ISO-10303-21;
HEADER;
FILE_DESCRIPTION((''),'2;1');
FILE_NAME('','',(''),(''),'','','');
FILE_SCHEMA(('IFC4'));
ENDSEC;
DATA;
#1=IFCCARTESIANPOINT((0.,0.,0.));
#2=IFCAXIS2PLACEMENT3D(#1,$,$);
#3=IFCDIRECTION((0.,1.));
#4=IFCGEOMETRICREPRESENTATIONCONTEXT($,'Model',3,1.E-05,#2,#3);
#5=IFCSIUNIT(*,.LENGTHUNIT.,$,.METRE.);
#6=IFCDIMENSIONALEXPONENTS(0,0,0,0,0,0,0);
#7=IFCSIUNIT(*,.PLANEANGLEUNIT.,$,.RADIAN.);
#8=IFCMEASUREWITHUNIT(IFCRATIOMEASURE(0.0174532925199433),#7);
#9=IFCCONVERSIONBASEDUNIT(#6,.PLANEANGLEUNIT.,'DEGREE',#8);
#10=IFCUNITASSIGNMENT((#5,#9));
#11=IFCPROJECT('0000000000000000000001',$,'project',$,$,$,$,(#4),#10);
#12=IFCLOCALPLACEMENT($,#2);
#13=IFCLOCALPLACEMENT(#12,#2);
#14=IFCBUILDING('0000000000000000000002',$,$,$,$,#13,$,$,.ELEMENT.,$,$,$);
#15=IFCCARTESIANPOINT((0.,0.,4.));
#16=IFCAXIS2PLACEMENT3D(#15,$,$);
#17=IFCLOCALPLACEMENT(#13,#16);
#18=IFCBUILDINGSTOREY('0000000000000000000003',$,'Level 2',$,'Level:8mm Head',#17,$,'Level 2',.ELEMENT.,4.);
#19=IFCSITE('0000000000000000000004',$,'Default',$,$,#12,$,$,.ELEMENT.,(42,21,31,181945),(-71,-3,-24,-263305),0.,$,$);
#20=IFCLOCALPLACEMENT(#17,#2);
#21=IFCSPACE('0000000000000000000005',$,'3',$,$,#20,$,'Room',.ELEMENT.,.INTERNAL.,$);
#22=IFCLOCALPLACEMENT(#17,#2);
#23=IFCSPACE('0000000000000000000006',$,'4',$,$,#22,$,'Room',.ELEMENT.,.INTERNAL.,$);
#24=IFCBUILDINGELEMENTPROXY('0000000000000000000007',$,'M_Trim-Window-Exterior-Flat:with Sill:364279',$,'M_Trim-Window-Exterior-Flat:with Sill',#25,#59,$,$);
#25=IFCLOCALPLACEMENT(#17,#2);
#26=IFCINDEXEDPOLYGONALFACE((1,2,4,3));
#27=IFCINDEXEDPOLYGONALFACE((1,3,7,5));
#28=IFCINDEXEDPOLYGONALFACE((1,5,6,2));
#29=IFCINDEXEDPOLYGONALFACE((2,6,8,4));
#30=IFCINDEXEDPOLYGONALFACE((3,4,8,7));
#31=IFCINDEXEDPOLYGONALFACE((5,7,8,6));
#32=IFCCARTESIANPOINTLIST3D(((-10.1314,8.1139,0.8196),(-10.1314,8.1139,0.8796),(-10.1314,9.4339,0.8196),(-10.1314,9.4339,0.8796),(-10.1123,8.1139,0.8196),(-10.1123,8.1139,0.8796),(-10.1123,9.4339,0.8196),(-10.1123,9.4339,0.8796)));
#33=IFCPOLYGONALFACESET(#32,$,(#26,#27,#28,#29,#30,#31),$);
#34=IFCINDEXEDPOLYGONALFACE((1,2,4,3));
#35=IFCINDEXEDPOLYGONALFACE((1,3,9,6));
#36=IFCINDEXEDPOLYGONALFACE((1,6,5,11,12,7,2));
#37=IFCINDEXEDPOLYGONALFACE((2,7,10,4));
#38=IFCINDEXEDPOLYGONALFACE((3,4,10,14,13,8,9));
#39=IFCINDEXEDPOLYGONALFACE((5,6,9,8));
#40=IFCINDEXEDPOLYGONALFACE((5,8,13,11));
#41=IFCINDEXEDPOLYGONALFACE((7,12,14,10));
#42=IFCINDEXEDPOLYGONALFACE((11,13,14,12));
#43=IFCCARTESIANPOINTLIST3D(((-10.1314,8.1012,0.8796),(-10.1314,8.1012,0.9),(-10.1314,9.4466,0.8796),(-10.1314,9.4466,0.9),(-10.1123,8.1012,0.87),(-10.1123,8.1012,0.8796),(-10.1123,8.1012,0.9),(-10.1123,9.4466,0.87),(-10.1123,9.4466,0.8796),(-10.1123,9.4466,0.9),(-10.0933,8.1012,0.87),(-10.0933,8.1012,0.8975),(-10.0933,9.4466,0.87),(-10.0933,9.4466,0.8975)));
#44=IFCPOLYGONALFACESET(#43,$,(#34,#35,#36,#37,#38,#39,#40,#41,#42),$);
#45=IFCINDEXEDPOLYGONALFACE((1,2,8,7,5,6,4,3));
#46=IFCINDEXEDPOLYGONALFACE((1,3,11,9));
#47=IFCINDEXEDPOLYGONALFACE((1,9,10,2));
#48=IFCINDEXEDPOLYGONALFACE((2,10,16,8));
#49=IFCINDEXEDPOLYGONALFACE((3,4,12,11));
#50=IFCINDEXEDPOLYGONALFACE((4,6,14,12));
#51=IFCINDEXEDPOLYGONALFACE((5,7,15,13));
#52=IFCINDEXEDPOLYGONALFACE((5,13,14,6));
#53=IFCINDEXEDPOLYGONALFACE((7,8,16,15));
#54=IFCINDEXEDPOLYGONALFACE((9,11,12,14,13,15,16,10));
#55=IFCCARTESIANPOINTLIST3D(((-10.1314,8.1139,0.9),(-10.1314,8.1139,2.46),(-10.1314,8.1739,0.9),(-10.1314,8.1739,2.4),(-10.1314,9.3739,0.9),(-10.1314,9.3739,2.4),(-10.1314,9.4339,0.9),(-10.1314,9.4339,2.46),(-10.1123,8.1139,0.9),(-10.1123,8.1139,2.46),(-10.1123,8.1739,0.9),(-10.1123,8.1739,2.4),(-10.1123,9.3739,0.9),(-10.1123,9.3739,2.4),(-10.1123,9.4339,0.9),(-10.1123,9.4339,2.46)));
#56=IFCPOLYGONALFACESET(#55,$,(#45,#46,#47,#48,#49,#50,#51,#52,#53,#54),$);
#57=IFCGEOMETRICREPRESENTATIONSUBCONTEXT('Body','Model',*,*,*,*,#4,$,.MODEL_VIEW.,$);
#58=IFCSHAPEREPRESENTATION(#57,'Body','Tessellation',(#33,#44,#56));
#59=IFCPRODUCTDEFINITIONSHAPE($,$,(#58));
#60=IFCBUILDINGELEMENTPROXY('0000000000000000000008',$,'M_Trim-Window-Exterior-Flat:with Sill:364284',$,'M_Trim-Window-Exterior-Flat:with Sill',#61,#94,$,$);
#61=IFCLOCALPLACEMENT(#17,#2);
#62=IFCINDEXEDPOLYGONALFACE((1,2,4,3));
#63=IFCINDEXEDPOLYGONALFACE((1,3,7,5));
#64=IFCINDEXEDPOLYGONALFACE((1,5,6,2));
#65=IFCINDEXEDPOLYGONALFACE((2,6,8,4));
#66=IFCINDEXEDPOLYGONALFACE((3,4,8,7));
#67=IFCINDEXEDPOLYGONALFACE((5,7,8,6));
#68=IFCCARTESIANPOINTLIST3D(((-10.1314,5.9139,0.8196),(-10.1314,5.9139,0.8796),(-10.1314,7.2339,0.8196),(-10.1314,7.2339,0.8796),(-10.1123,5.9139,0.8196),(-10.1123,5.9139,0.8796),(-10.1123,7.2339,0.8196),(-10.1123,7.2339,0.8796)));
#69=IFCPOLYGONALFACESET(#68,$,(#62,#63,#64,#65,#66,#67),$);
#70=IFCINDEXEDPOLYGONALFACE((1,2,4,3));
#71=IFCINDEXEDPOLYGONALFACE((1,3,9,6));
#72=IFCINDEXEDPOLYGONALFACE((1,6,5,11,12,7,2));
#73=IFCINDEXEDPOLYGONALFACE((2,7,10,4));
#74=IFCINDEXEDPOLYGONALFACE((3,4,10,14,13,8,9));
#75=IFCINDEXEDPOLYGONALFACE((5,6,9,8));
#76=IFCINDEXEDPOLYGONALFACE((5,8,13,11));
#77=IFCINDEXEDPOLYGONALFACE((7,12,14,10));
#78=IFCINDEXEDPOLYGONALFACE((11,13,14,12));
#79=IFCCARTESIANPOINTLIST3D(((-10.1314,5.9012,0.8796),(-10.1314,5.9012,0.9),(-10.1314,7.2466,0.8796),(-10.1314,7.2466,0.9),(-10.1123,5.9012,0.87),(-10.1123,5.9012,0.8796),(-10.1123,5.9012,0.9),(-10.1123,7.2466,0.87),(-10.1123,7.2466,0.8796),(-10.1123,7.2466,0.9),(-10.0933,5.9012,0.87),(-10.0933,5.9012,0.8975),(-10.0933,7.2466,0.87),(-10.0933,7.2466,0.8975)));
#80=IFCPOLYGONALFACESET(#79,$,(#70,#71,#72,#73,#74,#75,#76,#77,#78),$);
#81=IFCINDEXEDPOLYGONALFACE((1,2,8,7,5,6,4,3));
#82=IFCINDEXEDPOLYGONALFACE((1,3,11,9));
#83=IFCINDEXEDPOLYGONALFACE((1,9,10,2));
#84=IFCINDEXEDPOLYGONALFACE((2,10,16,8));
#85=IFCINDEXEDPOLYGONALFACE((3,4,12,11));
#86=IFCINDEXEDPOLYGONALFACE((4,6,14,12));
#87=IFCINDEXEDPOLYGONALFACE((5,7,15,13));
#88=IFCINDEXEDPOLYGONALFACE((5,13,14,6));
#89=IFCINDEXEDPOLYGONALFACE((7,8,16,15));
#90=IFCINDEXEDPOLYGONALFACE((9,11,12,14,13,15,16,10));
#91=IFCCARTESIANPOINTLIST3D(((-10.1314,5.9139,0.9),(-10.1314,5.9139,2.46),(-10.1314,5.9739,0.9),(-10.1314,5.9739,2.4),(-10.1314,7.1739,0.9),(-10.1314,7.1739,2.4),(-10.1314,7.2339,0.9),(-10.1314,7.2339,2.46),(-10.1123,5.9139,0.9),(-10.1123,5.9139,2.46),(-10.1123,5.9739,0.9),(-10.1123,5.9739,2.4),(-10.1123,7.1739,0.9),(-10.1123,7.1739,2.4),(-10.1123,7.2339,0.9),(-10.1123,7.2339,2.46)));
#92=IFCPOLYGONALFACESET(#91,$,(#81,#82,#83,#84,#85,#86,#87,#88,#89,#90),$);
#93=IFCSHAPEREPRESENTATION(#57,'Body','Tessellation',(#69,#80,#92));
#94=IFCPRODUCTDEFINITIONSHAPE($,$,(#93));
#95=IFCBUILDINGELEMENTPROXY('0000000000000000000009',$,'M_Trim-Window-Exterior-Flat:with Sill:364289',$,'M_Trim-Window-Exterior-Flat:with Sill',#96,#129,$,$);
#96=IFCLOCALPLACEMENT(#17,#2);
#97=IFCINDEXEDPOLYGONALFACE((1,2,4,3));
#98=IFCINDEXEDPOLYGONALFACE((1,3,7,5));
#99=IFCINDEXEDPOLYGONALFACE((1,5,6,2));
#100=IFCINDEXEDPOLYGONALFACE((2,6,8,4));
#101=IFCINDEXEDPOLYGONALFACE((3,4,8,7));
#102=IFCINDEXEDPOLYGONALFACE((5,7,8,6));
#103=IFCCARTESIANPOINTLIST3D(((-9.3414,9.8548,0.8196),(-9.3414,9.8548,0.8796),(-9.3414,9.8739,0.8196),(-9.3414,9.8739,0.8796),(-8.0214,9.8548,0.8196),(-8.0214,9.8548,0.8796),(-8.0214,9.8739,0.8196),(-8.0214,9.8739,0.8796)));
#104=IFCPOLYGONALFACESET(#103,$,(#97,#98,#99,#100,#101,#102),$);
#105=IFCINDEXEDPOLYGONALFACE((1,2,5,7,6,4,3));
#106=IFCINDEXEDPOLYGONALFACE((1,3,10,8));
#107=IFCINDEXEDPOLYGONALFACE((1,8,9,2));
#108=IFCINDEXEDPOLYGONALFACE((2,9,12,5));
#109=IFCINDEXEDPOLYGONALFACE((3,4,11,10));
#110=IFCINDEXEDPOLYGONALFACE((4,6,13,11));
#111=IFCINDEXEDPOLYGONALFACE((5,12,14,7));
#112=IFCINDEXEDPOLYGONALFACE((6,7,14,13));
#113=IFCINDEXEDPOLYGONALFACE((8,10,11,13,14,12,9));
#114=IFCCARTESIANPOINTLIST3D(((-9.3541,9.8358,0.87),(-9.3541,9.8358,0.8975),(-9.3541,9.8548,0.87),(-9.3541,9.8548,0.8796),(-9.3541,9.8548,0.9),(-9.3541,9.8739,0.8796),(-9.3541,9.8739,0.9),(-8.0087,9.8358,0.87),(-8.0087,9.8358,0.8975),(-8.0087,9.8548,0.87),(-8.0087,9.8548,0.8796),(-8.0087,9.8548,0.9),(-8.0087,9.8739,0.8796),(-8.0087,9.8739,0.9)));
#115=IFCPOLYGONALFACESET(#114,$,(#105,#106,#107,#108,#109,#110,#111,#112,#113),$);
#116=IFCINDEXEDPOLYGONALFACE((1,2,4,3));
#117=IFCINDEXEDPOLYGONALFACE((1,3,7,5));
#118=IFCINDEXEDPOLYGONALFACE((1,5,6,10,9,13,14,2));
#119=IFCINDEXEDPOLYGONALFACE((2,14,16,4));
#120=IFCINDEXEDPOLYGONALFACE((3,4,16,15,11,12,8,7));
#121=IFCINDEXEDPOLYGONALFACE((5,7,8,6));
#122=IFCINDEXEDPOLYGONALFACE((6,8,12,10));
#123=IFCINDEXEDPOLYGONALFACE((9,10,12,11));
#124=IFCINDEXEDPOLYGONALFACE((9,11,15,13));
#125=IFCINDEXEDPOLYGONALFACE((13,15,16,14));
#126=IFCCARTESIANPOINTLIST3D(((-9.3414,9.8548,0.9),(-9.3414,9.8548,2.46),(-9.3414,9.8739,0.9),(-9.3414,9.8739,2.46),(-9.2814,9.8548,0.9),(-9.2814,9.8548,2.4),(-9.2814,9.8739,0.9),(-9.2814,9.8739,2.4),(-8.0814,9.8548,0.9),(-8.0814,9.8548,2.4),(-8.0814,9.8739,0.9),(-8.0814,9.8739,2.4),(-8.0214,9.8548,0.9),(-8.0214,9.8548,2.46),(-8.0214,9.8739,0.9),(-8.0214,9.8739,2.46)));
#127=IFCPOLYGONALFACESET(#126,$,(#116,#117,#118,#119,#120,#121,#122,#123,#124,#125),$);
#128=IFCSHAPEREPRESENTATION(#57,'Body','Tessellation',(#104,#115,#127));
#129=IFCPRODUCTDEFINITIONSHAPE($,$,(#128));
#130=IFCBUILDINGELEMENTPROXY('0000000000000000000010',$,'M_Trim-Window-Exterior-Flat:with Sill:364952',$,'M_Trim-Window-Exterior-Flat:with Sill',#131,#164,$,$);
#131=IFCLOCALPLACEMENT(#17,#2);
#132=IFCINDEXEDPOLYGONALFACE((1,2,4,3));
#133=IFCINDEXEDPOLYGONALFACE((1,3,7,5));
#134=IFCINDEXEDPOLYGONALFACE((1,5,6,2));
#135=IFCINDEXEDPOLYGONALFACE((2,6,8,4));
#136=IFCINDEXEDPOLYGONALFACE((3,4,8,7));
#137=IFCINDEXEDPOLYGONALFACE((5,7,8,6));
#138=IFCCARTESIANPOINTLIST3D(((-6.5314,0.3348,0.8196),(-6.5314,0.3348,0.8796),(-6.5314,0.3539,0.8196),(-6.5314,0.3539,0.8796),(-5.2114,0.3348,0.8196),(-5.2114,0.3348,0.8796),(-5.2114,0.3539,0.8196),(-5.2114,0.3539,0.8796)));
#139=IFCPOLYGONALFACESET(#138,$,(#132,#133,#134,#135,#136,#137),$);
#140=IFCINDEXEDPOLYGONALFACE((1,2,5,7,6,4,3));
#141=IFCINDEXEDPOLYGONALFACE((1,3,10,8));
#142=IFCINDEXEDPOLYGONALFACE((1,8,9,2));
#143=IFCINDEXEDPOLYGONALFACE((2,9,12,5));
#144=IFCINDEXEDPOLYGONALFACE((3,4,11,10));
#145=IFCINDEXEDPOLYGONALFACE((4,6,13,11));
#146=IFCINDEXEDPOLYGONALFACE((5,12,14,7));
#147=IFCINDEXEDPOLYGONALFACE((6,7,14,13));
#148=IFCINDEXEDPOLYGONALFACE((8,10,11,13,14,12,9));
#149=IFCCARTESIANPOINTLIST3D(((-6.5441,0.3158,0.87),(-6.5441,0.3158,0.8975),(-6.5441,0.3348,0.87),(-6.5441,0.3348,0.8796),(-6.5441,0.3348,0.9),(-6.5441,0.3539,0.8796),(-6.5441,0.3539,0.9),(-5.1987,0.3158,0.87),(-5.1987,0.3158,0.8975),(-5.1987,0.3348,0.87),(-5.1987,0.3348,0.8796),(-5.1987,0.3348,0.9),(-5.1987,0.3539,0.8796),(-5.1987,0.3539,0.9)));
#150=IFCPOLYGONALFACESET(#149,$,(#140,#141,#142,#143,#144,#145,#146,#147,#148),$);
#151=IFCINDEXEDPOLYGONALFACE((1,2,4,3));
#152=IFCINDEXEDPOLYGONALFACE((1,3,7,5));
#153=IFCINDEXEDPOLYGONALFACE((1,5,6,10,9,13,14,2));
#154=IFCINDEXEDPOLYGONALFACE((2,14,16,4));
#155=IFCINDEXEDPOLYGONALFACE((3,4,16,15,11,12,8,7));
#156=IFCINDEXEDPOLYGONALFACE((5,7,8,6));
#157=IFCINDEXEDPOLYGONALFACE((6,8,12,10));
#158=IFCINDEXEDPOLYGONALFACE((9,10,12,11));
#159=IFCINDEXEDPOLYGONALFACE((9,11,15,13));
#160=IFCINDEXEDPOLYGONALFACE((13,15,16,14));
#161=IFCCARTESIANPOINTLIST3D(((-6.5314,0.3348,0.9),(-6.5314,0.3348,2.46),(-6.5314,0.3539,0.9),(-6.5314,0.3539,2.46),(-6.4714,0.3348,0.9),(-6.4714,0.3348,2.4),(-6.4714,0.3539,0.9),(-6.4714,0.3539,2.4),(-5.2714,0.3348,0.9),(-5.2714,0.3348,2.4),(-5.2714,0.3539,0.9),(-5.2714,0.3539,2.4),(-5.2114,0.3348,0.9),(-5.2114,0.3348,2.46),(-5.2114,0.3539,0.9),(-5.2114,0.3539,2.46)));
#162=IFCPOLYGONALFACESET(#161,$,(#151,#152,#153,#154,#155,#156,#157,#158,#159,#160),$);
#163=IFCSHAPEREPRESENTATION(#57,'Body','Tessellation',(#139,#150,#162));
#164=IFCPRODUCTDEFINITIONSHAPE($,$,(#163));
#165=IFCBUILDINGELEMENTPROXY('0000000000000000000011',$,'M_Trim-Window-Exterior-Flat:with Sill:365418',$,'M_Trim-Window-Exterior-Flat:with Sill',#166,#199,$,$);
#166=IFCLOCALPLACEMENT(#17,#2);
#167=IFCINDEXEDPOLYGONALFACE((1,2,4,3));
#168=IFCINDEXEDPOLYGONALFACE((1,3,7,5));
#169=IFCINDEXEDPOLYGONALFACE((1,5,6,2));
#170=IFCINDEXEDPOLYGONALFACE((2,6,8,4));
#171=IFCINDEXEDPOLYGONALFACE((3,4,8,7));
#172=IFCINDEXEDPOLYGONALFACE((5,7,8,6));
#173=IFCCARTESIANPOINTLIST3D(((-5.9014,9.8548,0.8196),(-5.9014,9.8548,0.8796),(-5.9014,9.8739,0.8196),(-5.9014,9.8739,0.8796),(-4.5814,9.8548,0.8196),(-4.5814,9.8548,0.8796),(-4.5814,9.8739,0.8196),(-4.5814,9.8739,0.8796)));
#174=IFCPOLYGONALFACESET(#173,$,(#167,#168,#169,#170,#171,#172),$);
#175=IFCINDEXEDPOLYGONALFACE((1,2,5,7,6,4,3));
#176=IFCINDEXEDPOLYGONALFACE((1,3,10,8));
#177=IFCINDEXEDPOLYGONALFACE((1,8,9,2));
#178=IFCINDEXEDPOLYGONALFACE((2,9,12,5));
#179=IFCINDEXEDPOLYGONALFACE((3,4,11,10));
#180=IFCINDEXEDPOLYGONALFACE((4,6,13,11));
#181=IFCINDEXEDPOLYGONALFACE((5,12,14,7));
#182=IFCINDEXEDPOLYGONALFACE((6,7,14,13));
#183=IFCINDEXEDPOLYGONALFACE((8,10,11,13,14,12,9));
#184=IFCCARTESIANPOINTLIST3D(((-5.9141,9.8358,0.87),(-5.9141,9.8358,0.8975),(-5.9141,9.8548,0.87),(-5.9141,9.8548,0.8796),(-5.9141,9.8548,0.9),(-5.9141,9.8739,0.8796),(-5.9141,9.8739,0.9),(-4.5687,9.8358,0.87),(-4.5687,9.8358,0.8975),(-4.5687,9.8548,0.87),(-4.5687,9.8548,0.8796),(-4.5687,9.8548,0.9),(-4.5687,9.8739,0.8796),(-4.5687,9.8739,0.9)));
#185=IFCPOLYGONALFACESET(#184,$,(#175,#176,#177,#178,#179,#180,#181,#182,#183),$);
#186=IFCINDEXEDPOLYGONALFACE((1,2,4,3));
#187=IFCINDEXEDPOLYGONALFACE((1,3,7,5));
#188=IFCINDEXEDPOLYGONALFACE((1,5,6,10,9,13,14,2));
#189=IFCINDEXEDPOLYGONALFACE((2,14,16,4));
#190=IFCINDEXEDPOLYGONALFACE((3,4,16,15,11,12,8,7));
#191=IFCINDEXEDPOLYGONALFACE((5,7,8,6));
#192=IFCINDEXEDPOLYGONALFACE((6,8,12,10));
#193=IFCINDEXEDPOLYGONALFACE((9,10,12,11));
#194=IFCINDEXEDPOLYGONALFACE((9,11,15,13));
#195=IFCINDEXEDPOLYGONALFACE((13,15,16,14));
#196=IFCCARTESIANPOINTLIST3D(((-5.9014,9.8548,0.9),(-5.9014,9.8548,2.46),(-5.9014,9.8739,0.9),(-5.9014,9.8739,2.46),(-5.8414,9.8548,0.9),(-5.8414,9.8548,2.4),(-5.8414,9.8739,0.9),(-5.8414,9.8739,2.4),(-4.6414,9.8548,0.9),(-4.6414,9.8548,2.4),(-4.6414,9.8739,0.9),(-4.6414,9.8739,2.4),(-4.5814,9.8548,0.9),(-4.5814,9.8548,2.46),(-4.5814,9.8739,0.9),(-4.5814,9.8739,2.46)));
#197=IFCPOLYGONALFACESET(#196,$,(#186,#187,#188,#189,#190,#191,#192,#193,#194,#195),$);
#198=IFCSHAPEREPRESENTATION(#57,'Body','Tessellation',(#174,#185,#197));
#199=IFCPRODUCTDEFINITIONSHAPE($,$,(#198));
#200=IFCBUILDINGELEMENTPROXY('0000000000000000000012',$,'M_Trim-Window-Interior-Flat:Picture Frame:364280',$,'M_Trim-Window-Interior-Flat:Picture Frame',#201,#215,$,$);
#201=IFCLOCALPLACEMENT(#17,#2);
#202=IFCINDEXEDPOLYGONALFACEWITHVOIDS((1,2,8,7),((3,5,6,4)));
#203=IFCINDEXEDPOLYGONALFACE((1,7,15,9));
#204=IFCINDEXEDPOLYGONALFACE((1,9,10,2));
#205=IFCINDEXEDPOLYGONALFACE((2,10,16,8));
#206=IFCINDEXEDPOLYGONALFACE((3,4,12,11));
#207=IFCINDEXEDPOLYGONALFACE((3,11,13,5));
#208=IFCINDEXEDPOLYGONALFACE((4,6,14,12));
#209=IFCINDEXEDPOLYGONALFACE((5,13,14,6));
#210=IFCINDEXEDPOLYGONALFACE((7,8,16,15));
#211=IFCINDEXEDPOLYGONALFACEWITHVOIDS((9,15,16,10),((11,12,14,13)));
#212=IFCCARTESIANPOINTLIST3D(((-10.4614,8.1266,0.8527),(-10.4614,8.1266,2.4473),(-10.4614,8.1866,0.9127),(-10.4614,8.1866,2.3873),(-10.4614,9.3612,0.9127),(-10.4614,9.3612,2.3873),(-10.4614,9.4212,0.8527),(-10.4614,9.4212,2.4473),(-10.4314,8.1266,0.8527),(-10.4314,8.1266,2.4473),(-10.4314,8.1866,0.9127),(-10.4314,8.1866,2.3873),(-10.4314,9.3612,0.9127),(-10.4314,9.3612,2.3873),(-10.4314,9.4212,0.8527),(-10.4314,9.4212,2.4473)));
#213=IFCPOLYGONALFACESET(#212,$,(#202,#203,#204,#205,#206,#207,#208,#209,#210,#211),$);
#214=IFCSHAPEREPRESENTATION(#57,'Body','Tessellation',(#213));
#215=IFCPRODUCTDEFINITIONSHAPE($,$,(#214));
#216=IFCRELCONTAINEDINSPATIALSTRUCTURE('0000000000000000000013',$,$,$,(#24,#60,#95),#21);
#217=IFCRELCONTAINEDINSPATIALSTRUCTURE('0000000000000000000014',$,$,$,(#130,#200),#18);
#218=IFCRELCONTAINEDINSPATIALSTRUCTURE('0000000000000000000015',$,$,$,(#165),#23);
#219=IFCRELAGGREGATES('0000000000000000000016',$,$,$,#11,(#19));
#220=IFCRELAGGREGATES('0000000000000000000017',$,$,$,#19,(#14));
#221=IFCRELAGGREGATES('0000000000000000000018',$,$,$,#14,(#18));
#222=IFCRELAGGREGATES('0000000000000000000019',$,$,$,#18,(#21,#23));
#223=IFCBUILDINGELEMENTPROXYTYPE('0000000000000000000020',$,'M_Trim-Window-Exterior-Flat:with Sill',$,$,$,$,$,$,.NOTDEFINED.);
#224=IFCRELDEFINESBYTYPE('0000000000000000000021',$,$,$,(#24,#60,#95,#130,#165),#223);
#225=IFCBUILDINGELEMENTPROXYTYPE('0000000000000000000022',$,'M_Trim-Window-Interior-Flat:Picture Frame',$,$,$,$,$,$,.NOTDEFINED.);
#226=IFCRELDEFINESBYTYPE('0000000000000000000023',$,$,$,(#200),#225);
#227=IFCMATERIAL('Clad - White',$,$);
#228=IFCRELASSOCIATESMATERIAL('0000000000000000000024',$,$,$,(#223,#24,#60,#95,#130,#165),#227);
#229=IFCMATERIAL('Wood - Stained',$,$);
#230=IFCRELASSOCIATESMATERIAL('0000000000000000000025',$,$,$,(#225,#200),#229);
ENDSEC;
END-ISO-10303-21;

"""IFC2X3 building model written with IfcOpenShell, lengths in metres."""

from ifc_helpers import new_model, entity, si_unit, converted_unit, direction, frame, frame_2d, origin, place, context, subcontext, project, spatial, polyline, rectangle, outline, extrude, source, transform, mapped, material, type_object, type_shapes, element, save


model = new_model("IFC2X3")

# Units and contexts
model_context = context("Model", 3, precision=1e-05, world=origin(), true_north=direction((0.0, 1.0)))
body_context = subcontext(model_context, "Body", "Model", "MODEL_VIEW")
ifc_project = project(units=[si_unit("LENGTHUNIT", "METRE"), converted_unit("PLANEANGLEUNIT", "DEGREE", entity("IfcRatioMeasure", 0.0174532925199433), si_unit("PLANEANGLEUNIT", "RADIAN"), dimensions=[0, 0, 0, 0, 0, 0, 0])], contexts=[model_context])

# Site, building, storey
site_placement = place(None, origin())
site = spatial("IfcSite", under=ifc_project, at=site_placement, Name="Default", CompositionType="ELEMENT", RefLatitude=(42, 21, 31, 181945), RefLongitude=(-71, -3, -24, -263305), RefElevation=0.0)
building_placement = place(site_placement, origin())
building = spatial("IfcBuilding", under=site, at=building_placement, CompositionType="ELEMENT")
storey_placement = place(building_placement, frame((0.0, 0.0, 4.0)))
storey = spatial("IfcBuildingStorey", under=building, at=storey_placement, Name="Level 2", ObjectType="Level:8mm Head", LongName="Level 2", CompositionType="ELEMENT", Elevation=4.0)

# Shared definitions
ifc_material_1 = material(Name="Clad - White")
ifc_material_2 = material(Name="Wood - Stained")

# Shared definitions
space_1_placement = place(storey_placement, origin())
space_1 = spatial("IfcSpace", under=storey, at=space_1_placement, Name="3", LongName="Room", CompositionType="ELEMENT", InteriorOrExteriorSpace="INTERNAL")

# Building element proxies
building_element_proxy_type_1 = type_object("IfcBuildingElementProxyType", Name="M_Trim-Window-Exterior-Flat:with Sill", PredefinedType="NOTDEFINED", material=ifc_material_1)
shared_shape_1 = source(origin(), body_context, "Body", "SweptSolid", [
    extrude(rectangle(XDim=1.32, YDim=0.06, at=frame_2d((0.0, 0.0), x_axis=(1.0, 0.0))), frame((0.0, -1.5504, 0.0), z_axis=(0.0, 0.0, 1.0), x_axis=(-1.0, 0.0, 0.0)), (0.0, 0.0, 1.0), 0.0191),
    extrude(outline(polyline([(-0.019, -0.0152), (0.0, -0.0152), (0.0, -0.0057), (0.019, -0.0057), (0.019, 0.0148), (0.0, 0.0148), (-0.019, 0.0123), (-0.019, -0.0152)])), frame((-0.6727, -1.5148, 0.019), z_axis=(1.0, 0.0, 0.0), x_axis=(0.0, 0.0, -1.0)), (0.0, 0.0, 1.0), 1.3454),
    extrude(outline(polyline([(-0.795, -0.66), (0.765, -0.66), (0.765, -0.6), (-0.735, -0.6), (-0.735, 0.6), (0.765, 0.6), (0.765, 0.66), (-0.795, 0.66), (-0.795, -0.66)])), frame((0.0, -0.735, 0.0), z_axis=(0.0, 0.0, 1.0), x_axis=(0.0, -1.0, 0.0)), (0.0, 0.0, 1.0), 0.0191),
])
type_shapes(building_element_proxy_type_1, [shared_shape_1])
for number, where, z_axis, x_axis, name in (
    (1, (-10.1314, 8.7739, 2.4), (1.0, 0.0, 0.0), (0.0, 1.0, 0.0), "M_Trim-Window-Exterior-Flat:with Sill:364279"),
    (2, (-10.1314, 6.5739, 2.4), (1.0, 0.0, 0.0), (0.0, 1.0, 0.0), "M_Trim-Window-Exterior-Flat:with Sill:364284"),
    (3, (-8.6814, 9.8739, 2.4), (0.0, -1.0, 0.0), (1.0, 0.0, 0.0), "M_Trim-Window-Exterior-Flat:with Sill:364289"),
):
    element("IfcBuildingElementProxy", number, at=place(space_1_placement, frame(where, z_axis=z_axis, x_axis=x_axis)), inside=space_1, type_object=building_element_proxy_type_1, material=ifc_material_1, Name=name, ObjectType="M_Trim-Window-Exterior-Flat:with Sill", context=body_context, shape_type="MappedRepresentation", body=[
        mapped(shared_shape_1, transform((0.0, 0.0, 0.0), scale=1.0)),
    ])
proxy_1_placement = place(storey_placement, frame((-5.8714, 0.3539, 2.4), z_axis=(0.0, -1.0, 0.0), x_axis=(1.0, 0.0, 0.0)))
element("IfcBuildingElementProxy", 4, at=proxy_1_placement, inside=storey, type_object=building_element_proxy_type_1, material=ifc_material_1, Name="M_Trim-Window-Exterior-Flat:with Sill:364952", ObjectType="M_Trim-Window-Exterior-Flat:with Sill", context=body_context, shape_type="MappedRepresentation", body=[
    mapped(shared_shape_1, transform((0.0, 0.0, 0.0), scale=1.0)),
])

# Shared definitions
space_2_placement = place(storey_placement, origin())
space_2 = spatial("IfcSpace", under=storey, at=space_2_placement, Name="4", LongName="Room", CompositionType="ELEMENT", InteriorOrExteriorSpace="INTERNAL")

# Building element proxies
proxy_2_placement = place(space_2_placement, frame((-5.2414, 9.8739, 2.4), z_axis=(0.0, -1.0, 0.0), x_axis=(1.0, 0.0, 0.0)))
element("IfcBuildingElementProxy", 5, at=proxy_2_placement, inside=space_2, type_object=building_element_proxy_type_1, material=ifc_material_1, Name="M_Trim-Window-Exterior-Flat:with Sill:365418", ObjectType="M_Trim-Window-Exterior-Flat:with Sill", context=body_context, shape_type="MappedRepresentation", body=[
    mapped(shared_shape_1, transform((0.0, 0.0, 0.0), scale=1.0)),
])
building_element_proxy_type_2 = type_object("IfcBuildingElementProxyType", Name="M_Trim-Window-Interior-Flat:Picture Frame", PredefinedType="NOTDEFINED", material=ifc_material_2)
shared_shape_2 = source(origin(), body_context, "Body", "SweptSolid", [
    extrude(outline(polyline([(-0.6473, -0.7973), (0.6473, -0.7973), (0.6473, 0.7973), (-0.6473, 0.7973), (-0.6473, -0.7973)]), holes=[polyline([(-0.5873, -0.7373), (-0.5873, 0.7373), (0.5873, 0.7373), (0.5873, -0.7373), (-0.5873, -0.7373)])]), frame((0.0, -0.75, 0.0), z_axis=(0.0, 0.0, 1.0), x_axis=(-1.0, 0.0, 0.0)), (0.0, 0.0, 1.0), 0.03),
])
type_shapes(building_element_proxy_type_2, [shared_shape_2])
for number, where, z_axis, x_axis, name in (
    (6, (-10.4314, 8.7739, 2.4), (-1.0, 0.0, 0.0), (0.0, -1.0, 0.0), "M_Trim-Window-Interior-Flat:Picture Frame:364280"),
):
    element("IfcBuildingElementProxy", number, at=place(storey_placement, frame(where, z_axis=z_axis, x_axis=x_axis)), inside=storey, type_object=building_element_proxy_type_2, material=ifc_material_2, Name=name, ObjectType="M_Trim-Window-Interior-Flat:Picture Frame", context=body_context, shape_type="MappedRepresentation", body=[
        mapped(shared_shape_2, transform((0.0, 0.0, 0.0), scale=1.0)),
    ])

save(model, "model.ifc")
